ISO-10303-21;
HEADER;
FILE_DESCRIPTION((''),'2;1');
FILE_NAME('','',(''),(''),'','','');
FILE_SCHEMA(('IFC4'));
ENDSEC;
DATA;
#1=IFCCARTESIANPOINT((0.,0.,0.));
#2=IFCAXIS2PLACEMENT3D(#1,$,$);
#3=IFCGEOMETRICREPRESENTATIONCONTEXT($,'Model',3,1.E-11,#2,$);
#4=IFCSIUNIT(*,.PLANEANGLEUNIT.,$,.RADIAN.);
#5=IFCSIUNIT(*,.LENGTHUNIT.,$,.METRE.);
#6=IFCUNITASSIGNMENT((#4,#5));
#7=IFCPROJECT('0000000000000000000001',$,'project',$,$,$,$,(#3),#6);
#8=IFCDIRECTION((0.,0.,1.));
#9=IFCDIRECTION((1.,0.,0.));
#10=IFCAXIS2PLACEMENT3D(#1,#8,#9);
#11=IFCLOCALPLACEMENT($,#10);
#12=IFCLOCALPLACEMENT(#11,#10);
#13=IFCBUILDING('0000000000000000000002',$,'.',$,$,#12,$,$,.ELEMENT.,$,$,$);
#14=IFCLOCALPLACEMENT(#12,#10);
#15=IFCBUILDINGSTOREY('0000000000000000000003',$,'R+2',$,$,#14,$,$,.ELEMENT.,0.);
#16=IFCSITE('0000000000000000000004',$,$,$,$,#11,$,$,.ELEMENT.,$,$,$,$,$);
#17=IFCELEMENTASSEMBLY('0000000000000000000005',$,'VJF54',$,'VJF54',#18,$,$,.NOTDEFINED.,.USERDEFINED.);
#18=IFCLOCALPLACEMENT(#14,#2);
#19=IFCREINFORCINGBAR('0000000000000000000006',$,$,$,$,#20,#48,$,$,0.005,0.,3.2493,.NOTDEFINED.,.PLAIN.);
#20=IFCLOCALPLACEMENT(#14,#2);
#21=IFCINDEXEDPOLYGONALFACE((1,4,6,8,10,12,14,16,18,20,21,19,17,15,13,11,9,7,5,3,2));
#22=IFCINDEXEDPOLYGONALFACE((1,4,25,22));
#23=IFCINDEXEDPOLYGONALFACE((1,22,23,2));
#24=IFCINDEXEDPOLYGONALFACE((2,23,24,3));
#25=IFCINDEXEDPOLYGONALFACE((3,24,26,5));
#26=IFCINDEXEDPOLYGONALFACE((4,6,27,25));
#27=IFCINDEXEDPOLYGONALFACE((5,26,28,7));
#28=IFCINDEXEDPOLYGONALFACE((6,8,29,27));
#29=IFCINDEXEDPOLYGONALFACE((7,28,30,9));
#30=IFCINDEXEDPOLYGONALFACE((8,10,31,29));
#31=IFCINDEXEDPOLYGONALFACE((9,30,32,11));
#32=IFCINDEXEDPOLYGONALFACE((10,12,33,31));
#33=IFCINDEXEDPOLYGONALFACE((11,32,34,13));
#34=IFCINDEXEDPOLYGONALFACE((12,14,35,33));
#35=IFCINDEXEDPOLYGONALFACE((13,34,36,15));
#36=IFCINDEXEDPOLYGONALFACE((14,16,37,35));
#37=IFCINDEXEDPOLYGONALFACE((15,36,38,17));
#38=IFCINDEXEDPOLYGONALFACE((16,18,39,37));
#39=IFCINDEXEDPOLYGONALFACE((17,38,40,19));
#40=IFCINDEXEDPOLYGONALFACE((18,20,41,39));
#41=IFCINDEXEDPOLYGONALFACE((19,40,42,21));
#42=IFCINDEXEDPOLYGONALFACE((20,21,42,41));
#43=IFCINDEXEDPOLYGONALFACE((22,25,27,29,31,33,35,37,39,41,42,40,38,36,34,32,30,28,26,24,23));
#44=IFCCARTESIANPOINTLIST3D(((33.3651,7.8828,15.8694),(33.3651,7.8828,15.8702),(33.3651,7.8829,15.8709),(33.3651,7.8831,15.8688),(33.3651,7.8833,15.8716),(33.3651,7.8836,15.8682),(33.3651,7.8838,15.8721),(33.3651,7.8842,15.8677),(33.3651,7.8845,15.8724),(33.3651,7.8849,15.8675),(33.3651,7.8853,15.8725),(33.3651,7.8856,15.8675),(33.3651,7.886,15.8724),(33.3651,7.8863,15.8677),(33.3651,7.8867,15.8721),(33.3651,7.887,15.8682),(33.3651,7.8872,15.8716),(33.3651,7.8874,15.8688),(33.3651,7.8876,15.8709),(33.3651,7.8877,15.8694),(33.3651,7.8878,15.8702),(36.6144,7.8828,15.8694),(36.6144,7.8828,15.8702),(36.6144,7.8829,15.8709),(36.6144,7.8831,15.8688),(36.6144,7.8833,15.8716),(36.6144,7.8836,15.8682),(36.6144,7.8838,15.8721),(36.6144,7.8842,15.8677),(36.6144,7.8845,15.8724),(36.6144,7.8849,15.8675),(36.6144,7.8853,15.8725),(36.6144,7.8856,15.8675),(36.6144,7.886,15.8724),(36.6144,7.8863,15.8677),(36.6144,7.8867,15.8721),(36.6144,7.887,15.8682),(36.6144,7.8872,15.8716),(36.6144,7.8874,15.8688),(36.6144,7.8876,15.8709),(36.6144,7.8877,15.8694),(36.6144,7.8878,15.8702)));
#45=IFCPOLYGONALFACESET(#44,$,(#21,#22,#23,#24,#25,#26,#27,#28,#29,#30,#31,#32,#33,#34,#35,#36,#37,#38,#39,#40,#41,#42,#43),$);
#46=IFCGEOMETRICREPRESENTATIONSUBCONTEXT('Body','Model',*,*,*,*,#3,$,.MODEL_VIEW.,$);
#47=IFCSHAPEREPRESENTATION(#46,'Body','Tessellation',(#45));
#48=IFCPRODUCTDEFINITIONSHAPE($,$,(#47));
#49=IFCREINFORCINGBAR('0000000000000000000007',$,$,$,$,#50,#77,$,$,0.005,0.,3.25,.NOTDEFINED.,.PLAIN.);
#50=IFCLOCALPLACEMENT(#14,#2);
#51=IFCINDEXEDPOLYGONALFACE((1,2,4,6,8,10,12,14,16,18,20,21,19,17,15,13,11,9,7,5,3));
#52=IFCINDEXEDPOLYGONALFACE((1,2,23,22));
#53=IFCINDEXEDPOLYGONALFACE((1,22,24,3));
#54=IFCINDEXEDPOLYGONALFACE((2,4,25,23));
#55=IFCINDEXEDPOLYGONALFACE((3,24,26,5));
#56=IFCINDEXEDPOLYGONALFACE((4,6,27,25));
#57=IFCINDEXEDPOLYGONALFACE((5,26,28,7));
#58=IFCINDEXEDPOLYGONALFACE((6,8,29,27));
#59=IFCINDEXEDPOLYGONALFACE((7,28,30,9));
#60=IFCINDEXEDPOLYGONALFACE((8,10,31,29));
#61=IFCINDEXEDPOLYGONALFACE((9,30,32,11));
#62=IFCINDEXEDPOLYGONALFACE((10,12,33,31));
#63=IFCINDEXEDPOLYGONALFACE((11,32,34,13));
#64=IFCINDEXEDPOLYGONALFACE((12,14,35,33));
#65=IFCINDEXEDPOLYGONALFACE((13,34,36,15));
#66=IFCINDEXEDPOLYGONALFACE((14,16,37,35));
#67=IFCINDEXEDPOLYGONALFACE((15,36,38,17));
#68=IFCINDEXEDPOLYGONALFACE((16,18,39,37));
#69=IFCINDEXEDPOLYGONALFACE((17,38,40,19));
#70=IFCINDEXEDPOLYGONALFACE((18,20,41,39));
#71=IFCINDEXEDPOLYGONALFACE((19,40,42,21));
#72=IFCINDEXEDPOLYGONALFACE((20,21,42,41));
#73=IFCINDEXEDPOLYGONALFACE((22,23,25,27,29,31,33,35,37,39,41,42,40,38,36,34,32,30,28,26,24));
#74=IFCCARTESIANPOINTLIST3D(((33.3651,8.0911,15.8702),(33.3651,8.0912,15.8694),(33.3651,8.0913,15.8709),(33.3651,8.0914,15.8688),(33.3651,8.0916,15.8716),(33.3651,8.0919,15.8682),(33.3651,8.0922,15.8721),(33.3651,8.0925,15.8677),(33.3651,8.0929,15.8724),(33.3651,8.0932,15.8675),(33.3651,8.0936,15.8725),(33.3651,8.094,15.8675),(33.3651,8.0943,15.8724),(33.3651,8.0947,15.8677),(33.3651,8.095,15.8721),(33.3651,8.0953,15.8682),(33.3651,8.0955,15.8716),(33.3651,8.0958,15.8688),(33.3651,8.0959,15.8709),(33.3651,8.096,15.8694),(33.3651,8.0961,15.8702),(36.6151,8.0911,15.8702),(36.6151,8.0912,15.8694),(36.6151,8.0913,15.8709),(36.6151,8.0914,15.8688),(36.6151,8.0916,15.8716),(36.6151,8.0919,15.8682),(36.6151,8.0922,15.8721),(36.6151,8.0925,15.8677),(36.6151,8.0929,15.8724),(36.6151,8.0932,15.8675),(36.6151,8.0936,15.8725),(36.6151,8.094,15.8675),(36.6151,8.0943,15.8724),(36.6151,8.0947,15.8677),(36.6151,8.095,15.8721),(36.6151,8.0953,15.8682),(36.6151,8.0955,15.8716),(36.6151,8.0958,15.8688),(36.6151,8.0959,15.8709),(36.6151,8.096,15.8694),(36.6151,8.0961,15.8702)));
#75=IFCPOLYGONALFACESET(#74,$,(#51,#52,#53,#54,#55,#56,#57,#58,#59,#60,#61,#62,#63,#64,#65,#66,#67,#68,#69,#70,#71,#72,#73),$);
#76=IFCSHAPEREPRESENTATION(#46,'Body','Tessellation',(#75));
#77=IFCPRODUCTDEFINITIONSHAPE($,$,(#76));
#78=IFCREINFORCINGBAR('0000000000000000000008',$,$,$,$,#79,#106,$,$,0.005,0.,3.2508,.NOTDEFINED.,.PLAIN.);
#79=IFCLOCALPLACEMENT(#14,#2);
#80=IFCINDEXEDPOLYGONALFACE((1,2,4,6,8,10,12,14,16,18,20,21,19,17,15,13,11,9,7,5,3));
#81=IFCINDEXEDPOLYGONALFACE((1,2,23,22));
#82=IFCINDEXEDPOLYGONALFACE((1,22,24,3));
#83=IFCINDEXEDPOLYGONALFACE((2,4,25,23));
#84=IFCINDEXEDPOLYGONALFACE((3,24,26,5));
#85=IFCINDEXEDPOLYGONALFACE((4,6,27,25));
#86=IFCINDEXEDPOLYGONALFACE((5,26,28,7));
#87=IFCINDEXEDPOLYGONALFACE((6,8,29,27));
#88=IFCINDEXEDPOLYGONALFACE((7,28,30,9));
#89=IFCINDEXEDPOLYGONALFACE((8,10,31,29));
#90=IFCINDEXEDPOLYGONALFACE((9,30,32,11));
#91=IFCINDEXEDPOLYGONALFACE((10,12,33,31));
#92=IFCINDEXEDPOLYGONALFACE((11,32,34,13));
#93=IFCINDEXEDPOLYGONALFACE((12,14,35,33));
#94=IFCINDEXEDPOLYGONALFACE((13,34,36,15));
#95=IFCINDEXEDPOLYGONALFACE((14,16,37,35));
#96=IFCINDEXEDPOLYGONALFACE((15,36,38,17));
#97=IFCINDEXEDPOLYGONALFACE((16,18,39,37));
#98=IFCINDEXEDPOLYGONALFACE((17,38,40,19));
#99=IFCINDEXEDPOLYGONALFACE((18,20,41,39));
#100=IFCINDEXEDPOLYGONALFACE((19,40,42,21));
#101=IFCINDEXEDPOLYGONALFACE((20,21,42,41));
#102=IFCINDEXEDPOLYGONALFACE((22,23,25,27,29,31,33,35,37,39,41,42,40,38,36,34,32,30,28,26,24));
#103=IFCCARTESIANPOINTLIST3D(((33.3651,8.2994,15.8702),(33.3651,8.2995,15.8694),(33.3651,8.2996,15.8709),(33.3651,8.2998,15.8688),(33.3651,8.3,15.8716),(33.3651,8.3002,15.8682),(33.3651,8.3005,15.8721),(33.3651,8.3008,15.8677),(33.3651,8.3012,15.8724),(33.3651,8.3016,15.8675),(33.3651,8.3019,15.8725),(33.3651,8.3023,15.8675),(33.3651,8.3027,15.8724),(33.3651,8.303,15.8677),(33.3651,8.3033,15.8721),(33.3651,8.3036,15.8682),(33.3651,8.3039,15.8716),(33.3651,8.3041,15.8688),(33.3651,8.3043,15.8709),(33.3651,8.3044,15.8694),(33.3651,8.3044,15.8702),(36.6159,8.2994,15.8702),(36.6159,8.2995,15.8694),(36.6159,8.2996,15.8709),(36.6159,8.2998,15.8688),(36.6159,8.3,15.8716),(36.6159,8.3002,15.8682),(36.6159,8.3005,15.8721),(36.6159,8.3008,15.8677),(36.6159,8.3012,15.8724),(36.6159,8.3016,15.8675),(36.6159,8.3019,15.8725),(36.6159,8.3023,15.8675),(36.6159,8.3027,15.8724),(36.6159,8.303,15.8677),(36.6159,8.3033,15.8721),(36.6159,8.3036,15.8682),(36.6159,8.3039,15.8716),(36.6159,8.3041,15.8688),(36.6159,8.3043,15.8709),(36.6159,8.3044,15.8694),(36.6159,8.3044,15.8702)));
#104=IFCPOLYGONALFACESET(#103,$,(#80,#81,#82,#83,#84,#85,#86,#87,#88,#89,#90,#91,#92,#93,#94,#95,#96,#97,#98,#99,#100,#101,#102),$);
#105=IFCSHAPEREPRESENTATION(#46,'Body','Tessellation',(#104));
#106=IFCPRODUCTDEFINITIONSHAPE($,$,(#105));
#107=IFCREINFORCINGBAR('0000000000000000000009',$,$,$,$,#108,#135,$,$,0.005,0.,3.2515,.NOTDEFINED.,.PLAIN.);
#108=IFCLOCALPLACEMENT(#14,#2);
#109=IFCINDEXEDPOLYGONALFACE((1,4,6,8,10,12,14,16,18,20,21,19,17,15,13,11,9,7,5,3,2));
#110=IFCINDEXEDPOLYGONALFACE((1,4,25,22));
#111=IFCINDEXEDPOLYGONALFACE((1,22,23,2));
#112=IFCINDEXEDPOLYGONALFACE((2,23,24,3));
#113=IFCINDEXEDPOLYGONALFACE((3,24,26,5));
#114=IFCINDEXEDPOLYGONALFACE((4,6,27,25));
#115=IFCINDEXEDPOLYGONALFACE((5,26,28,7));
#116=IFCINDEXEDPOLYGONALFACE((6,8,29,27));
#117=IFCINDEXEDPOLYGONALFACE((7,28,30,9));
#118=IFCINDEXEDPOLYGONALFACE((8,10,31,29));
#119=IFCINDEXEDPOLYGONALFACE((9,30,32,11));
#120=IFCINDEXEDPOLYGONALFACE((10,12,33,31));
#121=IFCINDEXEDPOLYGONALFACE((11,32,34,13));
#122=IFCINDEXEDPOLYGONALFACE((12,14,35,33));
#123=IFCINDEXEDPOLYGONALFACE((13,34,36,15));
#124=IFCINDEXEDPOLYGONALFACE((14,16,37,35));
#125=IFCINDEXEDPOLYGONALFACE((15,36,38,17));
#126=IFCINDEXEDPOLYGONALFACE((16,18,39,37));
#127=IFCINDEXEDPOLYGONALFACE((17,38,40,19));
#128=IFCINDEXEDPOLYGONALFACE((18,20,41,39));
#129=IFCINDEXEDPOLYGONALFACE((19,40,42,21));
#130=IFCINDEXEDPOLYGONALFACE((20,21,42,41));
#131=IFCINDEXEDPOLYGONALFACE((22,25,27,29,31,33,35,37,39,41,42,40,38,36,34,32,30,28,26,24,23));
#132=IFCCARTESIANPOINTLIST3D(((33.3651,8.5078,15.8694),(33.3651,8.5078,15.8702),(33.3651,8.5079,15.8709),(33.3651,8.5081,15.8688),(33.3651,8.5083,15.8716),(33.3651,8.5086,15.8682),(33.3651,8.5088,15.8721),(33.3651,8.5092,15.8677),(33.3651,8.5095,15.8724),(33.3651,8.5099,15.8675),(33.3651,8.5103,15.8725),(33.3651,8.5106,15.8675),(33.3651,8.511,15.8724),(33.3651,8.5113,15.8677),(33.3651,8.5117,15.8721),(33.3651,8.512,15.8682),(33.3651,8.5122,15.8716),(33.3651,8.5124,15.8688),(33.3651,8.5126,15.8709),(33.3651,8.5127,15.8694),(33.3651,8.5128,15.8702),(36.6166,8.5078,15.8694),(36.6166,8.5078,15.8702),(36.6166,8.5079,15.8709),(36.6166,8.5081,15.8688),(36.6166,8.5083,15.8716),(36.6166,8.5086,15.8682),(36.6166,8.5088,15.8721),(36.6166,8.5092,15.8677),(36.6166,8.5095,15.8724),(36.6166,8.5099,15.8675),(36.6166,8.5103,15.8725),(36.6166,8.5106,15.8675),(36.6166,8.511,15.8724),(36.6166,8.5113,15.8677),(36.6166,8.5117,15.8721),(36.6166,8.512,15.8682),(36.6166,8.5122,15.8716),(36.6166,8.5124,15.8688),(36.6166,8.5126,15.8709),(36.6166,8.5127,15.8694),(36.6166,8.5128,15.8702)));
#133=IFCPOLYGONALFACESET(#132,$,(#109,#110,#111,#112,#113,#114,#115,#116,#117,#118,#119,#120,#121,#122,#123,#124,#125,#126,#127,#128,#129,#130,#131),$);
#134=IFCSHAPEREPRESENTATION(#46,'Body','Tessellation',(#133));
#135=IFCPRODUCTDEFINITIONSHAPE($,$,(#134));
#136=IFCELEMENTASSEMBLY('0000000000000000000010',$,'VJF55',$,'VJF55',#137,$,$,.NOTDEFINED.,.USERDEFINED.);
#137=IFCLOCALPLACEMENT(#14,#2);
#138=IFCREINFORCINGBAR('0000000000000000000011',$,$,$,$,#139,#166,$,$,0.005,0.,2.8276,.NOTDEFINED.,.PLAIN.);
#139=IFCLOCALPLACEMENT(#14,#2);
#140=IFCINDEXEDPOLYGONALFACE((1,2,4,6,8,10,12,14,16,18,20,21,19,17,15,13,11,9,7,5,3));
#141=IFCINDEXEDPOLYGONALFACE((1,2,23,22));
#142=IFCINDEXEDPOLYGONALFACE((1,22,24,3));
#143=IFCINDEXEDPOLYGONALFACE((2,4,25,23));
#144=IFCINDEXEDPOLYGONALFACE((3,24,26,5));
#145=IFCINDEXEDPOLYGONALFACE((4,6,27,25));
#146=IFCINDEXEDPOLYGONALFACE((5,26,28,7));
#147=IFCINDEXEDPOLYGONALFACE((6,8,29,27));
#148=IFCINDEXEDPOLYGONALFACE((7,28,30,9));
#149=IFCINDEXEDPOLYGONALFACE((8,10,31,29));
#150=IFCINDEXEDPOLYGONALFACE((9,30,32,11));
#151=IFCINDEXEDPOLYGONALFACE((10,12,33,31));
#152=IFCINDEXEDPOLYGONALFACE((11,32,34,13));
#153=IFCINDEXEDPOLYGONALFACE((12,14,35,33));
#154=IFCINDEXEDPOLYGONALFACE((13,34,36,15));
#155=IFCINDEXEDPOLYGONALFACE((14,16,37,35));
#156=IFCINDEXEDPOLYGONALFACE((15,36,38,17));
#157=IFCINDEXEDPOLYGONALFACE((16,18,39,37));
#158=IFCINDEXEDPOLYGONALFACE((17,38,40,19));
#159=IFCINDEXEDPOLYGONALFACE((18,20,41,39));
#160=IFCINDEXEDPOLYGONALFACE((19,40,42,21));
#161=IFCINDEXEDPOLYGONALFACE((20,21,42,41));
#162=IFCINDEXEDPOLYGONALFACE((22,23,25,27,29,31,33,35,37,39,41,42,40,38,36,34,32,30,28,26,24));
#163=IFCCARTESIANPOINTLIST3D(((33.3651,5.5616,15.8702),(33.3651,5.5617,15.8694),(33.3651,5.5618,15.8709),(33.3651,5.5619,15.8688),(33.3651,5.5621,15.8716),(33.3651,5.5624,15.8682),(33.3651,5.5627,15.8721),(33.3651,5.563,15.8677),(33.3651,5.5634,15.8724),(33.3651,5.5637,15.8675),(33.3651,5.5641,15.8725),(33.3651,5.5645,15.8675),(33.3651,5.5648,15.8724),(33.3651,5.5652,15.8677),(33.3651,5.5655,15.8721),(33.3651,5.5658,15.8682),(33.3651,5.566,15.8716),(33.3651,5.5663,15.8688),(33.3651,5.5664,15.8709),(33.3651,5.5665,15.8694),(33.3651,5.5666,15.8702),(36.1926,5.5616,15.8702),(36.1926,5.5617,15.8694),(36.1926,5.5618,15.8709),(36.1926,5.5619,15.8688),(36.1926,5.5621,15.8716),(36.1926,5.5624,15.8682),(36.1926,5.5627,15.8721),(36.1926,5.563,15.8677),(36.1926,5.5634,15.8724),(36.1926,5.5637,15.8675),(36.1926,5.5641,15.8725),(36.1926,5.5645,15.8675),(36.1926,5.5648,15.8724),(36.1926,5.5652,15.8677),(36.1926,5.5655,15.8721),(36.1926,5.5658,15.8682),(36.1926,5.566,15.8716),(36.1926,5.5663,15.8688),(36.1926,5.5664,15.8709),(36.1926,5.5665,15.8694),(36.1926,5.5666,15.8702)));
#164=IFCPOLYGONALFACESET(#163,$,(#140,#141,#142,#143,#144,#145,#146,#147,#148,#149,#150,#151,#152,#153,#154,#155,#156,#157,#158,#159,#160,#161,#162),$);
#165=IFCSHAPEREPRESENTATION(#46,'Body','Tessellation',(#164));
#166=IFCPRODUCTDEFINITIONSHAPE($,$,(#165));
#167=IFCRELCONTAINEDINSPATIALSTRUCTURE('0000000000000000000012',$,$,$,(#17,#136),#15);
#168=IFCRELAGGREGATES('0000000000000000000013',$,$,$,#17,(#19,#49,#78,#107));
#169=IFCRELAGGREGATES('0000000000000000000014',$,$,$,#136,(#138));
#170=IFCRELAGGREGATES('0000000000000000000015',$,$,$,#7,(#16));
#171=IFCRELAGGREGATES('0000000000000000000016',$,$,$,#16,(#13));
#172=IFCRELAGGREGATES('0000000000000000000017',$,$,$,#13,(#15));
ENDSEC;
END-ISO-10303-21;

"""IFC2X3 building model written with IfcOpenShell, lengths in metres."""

from ifc_helpers import new_model, entity, si_unit, origin, origin_with_axes, place, context, subcontext, project, spatial, shape, element, aggregate, save


model = new_model("IFC2X3")

# Units and contexts
model_context = context("Model", 3, precision=1e-11, world=origin())
body_context = subcontext(model_context, "Body", "Model", "MODEL_VIEW")
ifc_project = project(units=[si_unit("PLANEANGLEUNIT", "RADIAN"), si_unit("LENGTHUNIT", "METRE")], contexts=[model_context])

# Site, building, storey
site_placement = place(None, origin_with_axes())
site = spatial("IfcSite", under=ifc_project, at=site_placement, CompositionType="ELEMENT")
building_placement = place(site_placement, origin_with_axes())
building = spatial("IfcBuilding", under=site, at=building_placement, Name=".", CompositionType="ELEMENT")
storey_placement = place(building_placement, origin_with_axes())
storey = spatial("IfcBuildingStorey", under=building, at=storey_placement, Name="R+2", CompositionType="ELEMENT", Elevation=0.0)

# Element assemblies, reinforcing bars
assembly_1_placement = place(storey_placement, origin_with_axes())
assembly_1 = element("IfcElementAssembly", 1, at=assembly_1_placement, inside=storey, Name="VJF54", ObjectType="VJF54", AssemblyPlace="NOTDEFINED", PredefinedType="USERDEFINED")
reinforcing_bar_1_placement = place(assembly_1_placement, origin_with_axes())
reinforcing_bar_1 = element("IfcReinforcingBar", 2, at=reinforcing_bar_1_placement, BarLength=3.2493, BarRole="NOTDEFINED", BarSurface="PLAIN", CrossSectionArea=0.0, NominalDiameter=0.005, shapes=[
    shape(body_context, "Body", "AdvancedSweptSolid", [entity("IfcSweptDiskSolid", entity("IfcPolyline", [entity("IfcCartesianPoint", [33.3651, 7.8853, 15.87]), entity("IfcCartesianPoint", [36.6144, 7.8853, 15.87])]), 0.0025, None, 0.0, 3.2493)]),
    shape(body_context, "Body", "AdvancedSweptSolid", [entity("IfcSweptDiskSolid", entity("IfcPolyline", [entity("IfcCartesianPoint", [33.3651, 7.8853, 15.87]), entity("IfcCartesianPoint", [36.6144, 7.8853, 15.87])]), 0.0025, None, 0.0, 3.2493)]),
])
reinforcing_bar_2_placement = place(assembly_1_placement, origin_with_axes())
reinforcing_bar_2 = element("IfcReinforcingBar", 3, at=reinforcing_bar_2_placement, BarLength=3.25, BarRole="NOTDEFINED", BarSurface="PLAIN", CrossSectionArea=0.0, NominalDiameter=0.005, shapes=[
    shape(body_context, "Body", "AdvancedSweptSolid", [entity("IfcSweptDiskSolid", entity("IfcPolyline", [entity("IfcCartesianPoint", [33.3651, 8.0936, 15.87]), entity("IfcCartesianPoint", [36.6151, 8.0936, 15.87])]), 0.0025, None, 0.0, 3.25)]),
    shape(body_context, "Body", "AdvancedSweptSolid", [entity("IfcSweptDiskSolid", entity("IfcPolyline", [entity("IfcCartesianPoint", [33.3651, 8.0936, 15.87]), entity("IfcCartesianPoint", [36.6151, 8.0936, 15.87])]), 0.0025, None, 0.0, 3.25)]),
])
reinforcing_bar_3_placement = place(assembly_1_placement, origin_with_axes())
reinforcing_bar_3 = element("IfcReinforcingBar", 4, at=reinforcing_bar_3_placement, BarLength=3.2508, BarRole="NOTDEFINED", BarSurface="PLAIN", CrossSectionArea=0.0, NominalDiameter=0.005, shapes=[
    shape(body_context, "Body", "AdvancedSweptSolid", [entity("IfcSweptDiskSolid", entity("IfcPolyline", [entity("IfcCartesianPoint", [33.3651, 8.3019, 15.87]), entity("IfcCartesianPoint", [36.6159, 8.3019, 15.87])]), 0.0025, None, 0.0, 3.2508)]),
    shape(body_context, "Body", "AdvancedSweptSolid", [entity("IfcSweptDiskSolid", entity("IfcPolyline", [entity("IfcCartesianPoint", [33.3651, 8.3019, 15.87]), entity("IfcCartesianPoint", [36.6159, 8.3019, 15.87])]), 0.0025, None, 0.0, 3.2508)]),
])
reinforcing_bar_4_placement = place(assembly_1_placement, origin_with_axes())
reinforcing_bar_4 = element("IfcReinforcingBar", 5, at=reinforcing_bar_4_placement, BarLength=3.2515, BarRole="NOTDEFINED", BarSurface="PLAIN", CrossSectionArea=0.0, NominalDiameter=0.005, shapes=[
    shape(body_context, "Body", "AdvancedSweptSolid", [entity("IfcSweptDiskSolid", entity("IfcPolyline", [entity("IfcCartesianPoint", [33.3651, 8.5103, 15.87]), entity("IfcCartesianPoint", [36.6166, 8.5103, 15.87])]), 0.0025, None, 0.0, 3.2515)]),
    shape(body_context, "Body", "AdvancedSweptSolid", [entity("IfcSweptDiskSolid", entity("IfcPolyline", [entity("IfcCartesianPoint", [33.3651, 8.5103, 15.87]), entity("IfcCartesianPoint", [36.6166, 8.5103, 15.87])]), 0.0025, None, 0.0, 3.2515)]),
])
aggregate(assembly_1, [reinforcing_bar_1, reinforcing_bar_2, reinforcing_bar_3, reinforcing_bar_4])
assembly_2_placement = place(storey_placement, origin_with_axes())
assembly_2 = element("IfcElementAssembly", 6, at=assembly_2_placement, inside=storey, Name="VJF55", ObjectType="VJF55", AssemblyPlace="NOTDEFINED", PredefinedType="USERDEFINED")
reinforcing_bar_5_placement = place(assembly_2_placement, origin_with_axes())
reinforcing_bar_5 = element("IfcReinforcingBar", 7, at=reinforcing_bar_5_placement, BarLength=2.8276, BarRole="NOTDEFINED", BarSurface="PLAIN", CrossSectionArea=0.0, NominalDiameter=0.005, shapes=[
    shape(body_context, "Body", "AdvancedSweptSolid", [entity("IfcSweptDiskSolid", entity("IfcPolyline", [entity("IfcCartesianPoint", [33.3651, 5.5641, 15.87]), entity("IfcCartesianPoint", [36.1926, 5.5641, 15.87])]), 0.0025, None, 0.0, 2.8276)]),
    shape(body_context, "Body", "AdvancedSweptSolid", [entity("IfcSweptDiskSolid", entity("IfcPolyline", [entity("IfcCartesianPoint", [33.3651, 5.5641, 15.87]), entity("IfcCartesianPoint", [36.1926, 5.5641, 15.87])]), 0.0025, None, 0.0, 2.8276)]),
])
aggregate(assembly_2, [reinforcing_bar_5])

save(model, "model.ifc")
